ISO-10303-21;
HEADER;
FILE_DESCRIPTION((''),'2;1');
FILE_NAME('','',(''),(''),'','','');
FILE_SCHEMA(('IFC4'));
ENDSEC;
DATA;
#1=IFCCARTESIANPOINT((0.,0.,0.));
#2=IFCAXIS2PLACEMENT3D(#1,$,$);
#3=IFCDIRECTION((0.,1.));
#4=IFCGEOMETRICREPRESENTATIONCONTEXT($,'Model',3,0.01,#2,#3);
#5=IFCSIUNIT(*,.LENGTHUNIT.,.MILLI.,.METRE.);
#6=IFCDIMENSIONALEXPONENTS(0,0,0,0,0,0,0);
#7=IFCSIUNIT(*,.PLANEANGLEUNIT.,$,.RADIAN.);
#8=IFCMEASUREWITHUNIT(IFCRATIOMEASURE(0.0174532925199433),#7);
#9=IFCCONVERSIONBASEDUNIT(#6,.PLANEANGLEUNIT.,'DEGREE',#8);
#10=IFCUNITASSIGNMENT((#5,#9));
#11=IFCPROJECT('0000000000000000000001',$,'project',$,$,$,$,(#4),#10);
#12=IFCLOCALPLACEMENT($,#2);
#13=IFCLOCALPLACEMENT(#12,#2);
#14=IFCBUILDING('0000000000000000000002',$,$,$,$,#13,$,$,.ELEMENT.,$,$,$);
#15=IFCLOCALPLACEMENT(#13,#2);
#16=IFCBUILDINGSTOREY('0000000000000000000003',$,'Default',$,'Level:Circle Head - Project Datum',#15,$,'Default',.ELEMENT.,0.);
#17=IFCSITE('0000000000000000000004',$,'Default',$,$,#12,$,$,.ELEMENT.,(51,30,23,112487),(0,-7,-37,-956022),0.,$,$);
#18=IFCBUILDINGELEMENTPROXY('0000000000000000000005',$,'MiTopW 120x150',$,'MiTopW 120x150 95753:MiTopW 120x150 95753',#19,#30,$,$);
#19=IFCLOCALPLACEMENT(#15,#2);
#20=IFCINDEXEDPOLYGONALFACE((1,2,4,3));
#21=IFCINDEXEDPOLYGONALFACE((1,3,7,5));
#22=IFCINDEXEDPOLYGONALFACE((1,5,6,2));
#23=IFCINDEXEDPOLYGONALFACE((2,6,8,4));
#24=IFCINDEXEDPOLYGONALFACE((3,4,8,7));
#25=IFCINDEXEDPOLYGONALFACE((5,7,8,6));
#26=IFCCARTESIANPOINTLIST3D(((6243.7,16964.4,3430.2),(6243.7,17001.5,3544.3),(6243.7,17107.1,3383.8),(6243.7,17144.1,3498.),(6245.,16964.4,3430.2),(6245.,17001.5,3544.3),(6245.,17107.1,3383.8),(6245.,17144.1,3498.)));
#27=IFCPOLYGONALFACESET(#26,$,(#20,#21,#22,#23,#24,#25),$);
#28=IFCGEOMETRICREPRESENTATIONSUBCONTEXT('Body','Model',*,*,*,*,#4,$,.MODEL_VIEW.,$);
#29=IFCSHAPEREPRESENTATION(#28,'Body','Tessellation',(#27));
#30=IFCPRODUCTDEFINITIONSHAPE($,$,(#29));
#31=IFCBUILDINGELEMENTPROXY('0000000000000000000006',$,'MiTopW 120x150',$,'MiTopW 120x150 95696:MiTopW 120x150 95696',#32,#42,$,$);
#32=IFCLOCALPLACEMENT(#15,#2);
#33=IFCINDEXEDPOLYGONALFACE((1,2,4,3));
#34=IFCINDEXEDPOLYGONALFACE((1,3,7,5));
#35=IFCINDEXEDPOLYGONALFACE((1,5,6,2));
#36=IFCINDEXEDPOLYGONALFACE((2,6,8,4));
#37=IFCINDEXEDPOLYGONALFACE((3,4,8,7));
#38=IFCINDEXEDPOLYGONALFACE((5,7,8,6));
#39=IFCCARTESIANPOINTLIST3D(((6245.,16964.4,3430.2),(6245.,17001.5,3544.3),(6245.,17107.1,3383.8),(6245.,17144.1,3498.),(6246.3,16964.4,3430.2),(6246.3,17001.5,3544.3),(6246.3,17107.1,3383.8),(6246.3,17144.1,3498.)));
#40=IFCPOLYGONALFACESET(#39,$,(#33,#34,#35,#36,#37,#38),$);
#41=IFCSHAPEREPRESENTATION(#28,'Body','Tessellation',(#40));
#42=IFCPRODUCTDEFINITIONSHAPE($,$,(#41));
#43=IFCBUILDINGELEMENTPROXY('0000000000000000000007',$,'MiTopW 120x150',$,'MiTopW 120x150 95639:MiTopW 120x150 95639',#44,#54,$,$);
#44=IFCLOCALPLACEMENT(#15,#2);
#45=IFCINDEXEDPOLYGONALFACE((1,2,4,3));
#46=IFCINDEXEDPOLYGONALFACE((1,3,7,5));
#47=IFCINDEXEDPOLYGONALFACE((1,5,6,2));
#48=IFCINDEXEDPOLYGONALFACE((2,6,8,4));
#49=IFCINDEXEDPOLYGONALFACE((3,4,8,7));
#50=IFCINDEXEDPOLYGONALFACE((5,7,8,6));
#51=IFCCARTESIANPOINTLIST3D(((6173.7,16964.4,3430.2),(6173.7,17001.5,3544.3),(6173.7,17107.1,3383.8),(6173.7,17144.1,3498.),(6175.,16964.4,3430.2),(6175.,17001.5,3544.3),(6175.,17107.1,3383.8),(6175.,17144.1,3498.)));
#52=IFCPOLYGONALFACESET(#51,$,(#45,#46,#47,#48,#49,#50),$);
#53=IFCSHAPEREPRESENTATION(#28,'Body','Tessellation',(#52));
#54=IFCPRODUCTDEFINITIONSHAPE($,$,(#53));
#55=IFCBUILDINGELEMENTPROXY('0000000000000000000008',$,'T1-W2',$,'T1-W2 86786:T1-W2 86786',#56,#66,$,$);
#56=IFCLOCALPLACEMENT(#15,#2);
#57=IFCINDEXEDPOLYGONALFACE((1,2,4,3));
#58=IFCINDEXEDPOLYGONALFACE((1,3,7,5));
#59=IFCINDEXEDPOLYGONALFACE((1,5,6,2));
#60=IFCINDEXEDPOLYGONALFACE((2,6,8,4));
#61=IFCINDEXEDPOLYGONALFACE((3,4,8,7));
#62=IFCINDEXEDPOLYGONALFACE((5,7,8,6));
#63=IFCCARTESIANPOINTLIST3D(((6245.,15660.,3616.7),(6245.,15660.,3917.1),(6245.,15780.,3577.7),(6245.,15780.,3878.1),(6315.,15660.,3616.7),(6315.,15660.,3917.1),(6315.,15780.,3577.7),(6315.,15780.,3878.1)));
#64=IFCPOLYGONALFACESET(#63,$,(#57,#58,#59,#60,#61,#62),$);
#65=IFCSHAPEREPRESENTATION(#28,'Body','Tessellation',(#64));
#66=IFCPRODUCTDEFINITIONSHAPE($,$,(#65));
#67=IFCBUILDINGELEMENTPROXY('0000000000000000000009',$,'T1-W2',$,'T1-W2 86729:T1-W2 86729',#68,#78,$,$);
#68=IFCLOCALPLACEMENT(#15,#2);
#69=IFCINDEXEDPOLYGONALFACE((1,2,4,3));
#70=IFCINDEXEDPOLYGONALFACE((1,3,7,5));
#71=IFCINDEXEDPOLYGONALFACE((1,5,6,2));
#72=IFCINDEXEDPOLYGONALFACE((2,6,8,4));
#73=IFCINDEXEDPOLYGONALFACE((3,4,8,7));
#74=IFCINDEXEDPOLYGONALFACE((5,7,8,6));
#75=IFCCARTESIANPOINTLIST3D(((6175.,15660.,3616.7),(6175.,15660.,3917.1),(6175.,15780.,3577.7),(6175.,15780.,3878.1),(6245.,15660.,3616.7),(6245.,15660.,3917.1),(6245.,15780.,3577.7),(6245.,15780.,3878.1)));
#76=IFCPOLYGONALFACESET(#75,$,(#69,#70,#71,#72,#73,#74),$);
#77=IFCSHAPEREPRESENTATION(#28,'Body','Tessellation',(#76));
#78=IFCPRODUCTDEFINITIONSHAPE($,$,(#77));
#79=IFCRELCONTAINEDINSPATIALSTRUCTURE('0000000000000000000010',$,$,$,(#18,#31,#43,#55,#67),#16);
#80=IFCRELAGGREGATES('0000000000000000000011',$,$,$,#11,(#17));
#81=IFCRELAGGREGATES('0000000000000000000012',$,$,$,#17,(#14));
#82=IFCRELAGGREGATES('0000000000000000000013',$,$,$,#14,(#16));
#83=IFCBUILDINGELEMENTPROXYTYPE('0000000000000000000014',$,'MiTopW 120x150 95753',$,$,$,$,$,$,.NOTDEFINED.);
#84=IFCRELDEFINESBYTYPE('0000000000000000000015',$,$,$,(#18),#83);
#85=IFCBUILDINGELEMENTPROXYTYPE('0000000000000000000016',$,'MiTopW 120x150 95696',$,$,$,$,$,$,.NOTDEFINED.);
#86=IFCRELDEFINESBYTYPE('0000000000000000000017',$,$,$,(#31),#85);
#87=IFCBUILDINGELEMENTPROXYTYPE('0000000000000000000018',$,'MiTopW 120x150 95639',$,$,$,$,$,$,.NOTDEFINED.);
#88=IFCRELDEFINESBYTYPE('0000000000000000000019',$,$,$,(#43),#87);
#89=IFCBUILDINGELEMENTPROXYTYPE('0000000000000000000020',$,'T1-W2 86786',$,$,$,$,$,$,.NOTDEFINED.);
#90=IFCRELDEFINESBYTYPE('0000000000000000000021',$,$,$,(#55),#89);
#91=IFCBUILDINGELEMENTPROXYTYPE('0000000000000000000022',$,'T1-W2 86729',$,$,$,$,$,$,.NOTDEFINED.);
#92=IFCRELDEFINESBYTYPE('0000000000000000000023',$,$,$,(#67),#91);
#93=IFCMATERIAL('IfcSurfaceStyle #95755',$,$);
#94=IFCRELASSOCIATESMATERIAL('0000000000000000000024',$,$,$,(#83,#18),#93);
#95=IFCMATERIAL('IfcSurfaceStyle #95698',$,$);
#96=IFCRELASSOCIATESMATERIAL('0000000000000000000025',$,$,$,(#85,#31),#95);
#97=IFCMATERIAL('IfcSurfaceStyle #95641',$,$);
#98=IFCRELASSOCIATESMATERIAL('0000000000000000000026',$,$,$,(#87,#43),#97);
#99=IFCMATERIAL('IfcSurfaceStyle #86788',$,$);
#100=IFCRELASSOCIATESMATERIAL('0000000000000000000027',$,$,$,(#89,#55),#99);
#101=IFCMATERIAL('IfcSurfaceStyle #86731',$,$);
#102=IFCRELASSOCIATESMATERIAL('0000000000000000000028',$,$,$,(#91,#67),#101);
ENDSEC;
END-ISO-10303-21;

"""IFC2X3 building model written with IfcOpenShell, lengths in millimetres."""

from ifc_helpers import new_model, entity, si_unit, converted_unit, direction, frame, origin, place, context, subcontext, project, spatial, polyline, outline, extrude, source, transform, mapped, material, type_object, type_shapes, element, save


model = new_model("IFC2X3")

# Units and contexts
model_context = context("Model", 3, precision=0.01, world=origin(), true_north=direction((0.0, 1.0)))
body_context = subcontext(model_context, "Body", "Model", "MODEL_VIEW")
ifc_project = project(units=[si_unit("LENGTHUNIT", "METRE", prefix="MILLI"), converted_unit("PLANEANGLEUNIT", "DEGREE", entity("IfcRatioMeasure", 0.0174532925199433), si_unit("PLANEANGLEUNIT", "RADIAN"), dimensions=[0, 0, 0, 0, 0, 0, 0])], contexts=[model_context])

# Site, building, storey
site_placement = place(None, origin())
site = spatial("IfcSite", under=ifc_project, at=site_placement, Name="Default", CompositionType="ELEMENT", RefLatitude=(51, 30, 23, 112487), RefLongitude=(0, -7, -37, -956022), RefElevation=0.0)
building_placement = place(site_placement, origin())
building = spatial("IfcBuilding", under=site, at=building_placement, CompositionType="ELEMENT")
storey_placement = place(building_placement, origin())
storey = spatial("IfcBuildingStorey", under=building, at=storey_placement, Name="Default", ObjectType="Level:Circle Head - Project Datum", LongName="Default", CompositionType="ELEMENT", Elevation=0.0)

# Building element proxies
ifc_material_1 = material(Name="IfcSurfaceStyle #95755")
building_element_proxy_type_1 = type_object("IfcBuildingElementProxyType", Name="MiTopW 120x150 95753", PredefinedType="NOTDEFINED", material=ifc_material_1)
shared_shape_1 = source(origin(), body_context, "Body", "SweptSolid", [
    extrude(outline(polyline([(-75.0, -60.0), (75.0, -60.0), (75.0, 60.0), (-75.0, 60.0), (-75.0, -60.0)])), frame((75.0, 60.0, 0.0), z_axis=(0.0, 0.0, 1.0), x_axis=(-1.0, 0.0, 0.0)), (0.0, 0.0, 1.0), 1.3),
])
type_shapes(building_element_proxy_type_1, [shared_shape_1])
proxy_1_placement = place(building_placement, frame((6245.0, 17107.1, 3383.8), z_axis=(-1.0, 0.0, 0.0), x_axis=(0.0, -0.951057, 0.309017)))
element("IfcBuildingElementProxy", 1, at=proxy_1_placement, inside=storey, type_object=building_element_proxy_type_1, material=ifc_material_1, Name="MiTopW 120x150", ObjectType="MiTopW 120x150 95753:MiTopW 120x150 95753", context=body_context, shape_type="MappedRepresentation", body=[
    mapped(shared_shape_1, transform((0.0, 0.0, 0.0), scale=1.0)),
])
ifc_material_2 = material(Name="IfcSurfaceStyle #95698")
building_element_proxy_type_2 = type_object("IfcBuildingElementProxyType", Name="MiTopW 120x150 95696", PredefinedType="NOTDEFINED", material=ifc_material_2)
shared_shape_2 = source(origin(), body_context, "Body", "SweptSolid", [
    extrude(outline(polyline([(-75.0, -60.0), (75.0, -60.0), (75.0, 60.0), (-75.0, 60.0), (-75.0, -60.0)])), frame((75.0, 60.0, 0.0), z_axis=(0.0, 0.0, 1.0), x_axis=(-1.0, 0.0, 0.0)), (0.0, 0.0, 1.0), 1.3),
])
type_shapes(building_element_proxy_type_2, [shared_shape_2])
proxy_2_placement = place(building_placement, frame((6246.3, 17107.1, 3383.8), z_axis=(-1.0, 0.0, 0.0), x_axis=(0.0, -0.951057, 0.309017)))
element("IfcBuildingElementProxy", 2, at=proxy_2_placement, inside=storey, type_object=building_element_proxy_type_2, material=ifc_material_2, Name="MiTopW 120x150", ObjectType="MiTopW 120x150 95696:MiTopW 120x150 95696", context=body_context, shape_type="MappedRepresentation", body=[
    mapped(shared_shape_2, transform((0.0, 0.0, 0.0), scale=1.0)),
])
ifc_material_3 = material(Name="IfcSurfaceStyle #95641")
building_element_proxy_type_3 = type_object("IfcBuildingElementProxyType", Name="MiTopW 120x150 95639", PredefinedType="NOTDEFINED", material=ifc_material_3)
shared_shape_3 = source(origin(), body_context, "Body", "SweptSolid", [
    extrude(outline(polyline([(-75.0, -60.0), (75.0, -60.0), (75.0, 60.0), (-75.0, 60.0), (-75.0, -60.0)])), frame((75.0, 60.0, 0.0), z_axis=(0.0, 0.0, 1.0), x_axis=(-1.0, 0.0, 0.0)), (0.0, 0.0, 1.0), 1.3),
])
type_shapes(building_element_proxy_type_3, [shared_shape_3])
proxy_3_placement = place(building_placement, frame((6175.0, 17107.1, 3383.8), z_axis=(-1.0, 0.0, 0.0), x_axis=(0.0, -0.951057, 0.309017)))
element("IfcBuildingElementProxy", 3, at=proxy_3_placement, inside=storey, type_object=building_element_proxy_type_3, material=ifc_material_3, Name="MiTopW 120x150", ObjectType="MiTopW 120x150 95639:MiTopW 120x150 95639", context=body_context, shape_type="MappedRepresentation", body=[
    mapped(shared_shape_3, transform((0.0, 0.0, 0.0), scale=1.0)),
])
ifc_material_4 = material(Name="IfcSurfaceStyle #86788")
building_element_proxy_type_4 = type_object("IfcBuildingElementProxyType", Name="T1-W2 86786", PredefinedType="NOTDEFINED", material=ifc_material_4)
shared_shape_4 = source(origin(), body_context, "Body", "SweptSolid", [
    extrude(outline(polyline([(-130.7, -60.0), (169.7, -60.0), (130.7, 60.0), (-169.7, 60.0), (-130.7, -60.0)])), frame((169.7, 60.0, 0.0), z_axis=(0.0, 0.0, 1.0), x_axis=(-1.0, 0.0, 0.0)), (0.0, 0.0, 1.0), 70.0),
])
type_shapes(building_element_proxy_type_4, [shared_shape_4])
proxy_4_placement = place(building_placement, frame((6315.0, 15660.0, 3577.7), z_axis=(-1.0, 0.0, 0.0), x_axis=(0.0, 0.0, 1.0)))
element("IfcBuildingElementProxy", 4, at=proxy_4_placement, inside=storey, type_object=building_element_proxy_type_4, material=ifc_material_4, Name="T1-W2", ObjectType="T1-W2 86786:T1-W2 86786", context=body_context, shape_type="MappedRepresentation", body=[
    mapped(shared_shape_4, transform((0.0, 0.0, 0.0), scale=1.0)),
])
ifc_material_5 = material(Name="IfcSurfaceStyle #86731")
building_element_proxy_type_5 = type_object("IfcBuildingElementProxyType", Name="T1-W2 86729", PredefinedType="NOTDEFINED", material=ifc_material_5)
shared_shape_5 = source(origin(), body_context, "Body", "SweptSolid", [
    extrude(outline(polyline([(-130.7, -60.0), (169.7, -60.0), (130.7, 60.0), (-169.7, 60.0), (-130.7, -60.0)])), frame((169.7, 60.0, 0.0), z_axis=(0.0, 0.0, 1.0), x_axis=(-1.0, 0.0, 0.0)), (0.0, 0.0, 1.0), 70.0),
])
type_shapes(building_element_proxy_type_5, [shared_shape_5])
proxy_5_placement = place(building_placement, frame((6245.0, 15660.0, 3577.7), z_axis=(-1.0, 0.0, 0.0), x_axis=(0.0, 0.0, 1.0)))
element("IfcBuildingElementProxy", 5, at=proxy_5_placement, inside=storey, type_object=building_element_proxy_type_5, material=ifc_material_5, Name="T1-W2", ObjectType="T1-W2 86729:T1-W2 86729", context=body_context, shape_type="MappedRepresentation", body=[
    mapped(shared_shape_5, transform((0.0, 0.0, 0.0), scale=1.0)),
])

save(model, "model.ifc")
